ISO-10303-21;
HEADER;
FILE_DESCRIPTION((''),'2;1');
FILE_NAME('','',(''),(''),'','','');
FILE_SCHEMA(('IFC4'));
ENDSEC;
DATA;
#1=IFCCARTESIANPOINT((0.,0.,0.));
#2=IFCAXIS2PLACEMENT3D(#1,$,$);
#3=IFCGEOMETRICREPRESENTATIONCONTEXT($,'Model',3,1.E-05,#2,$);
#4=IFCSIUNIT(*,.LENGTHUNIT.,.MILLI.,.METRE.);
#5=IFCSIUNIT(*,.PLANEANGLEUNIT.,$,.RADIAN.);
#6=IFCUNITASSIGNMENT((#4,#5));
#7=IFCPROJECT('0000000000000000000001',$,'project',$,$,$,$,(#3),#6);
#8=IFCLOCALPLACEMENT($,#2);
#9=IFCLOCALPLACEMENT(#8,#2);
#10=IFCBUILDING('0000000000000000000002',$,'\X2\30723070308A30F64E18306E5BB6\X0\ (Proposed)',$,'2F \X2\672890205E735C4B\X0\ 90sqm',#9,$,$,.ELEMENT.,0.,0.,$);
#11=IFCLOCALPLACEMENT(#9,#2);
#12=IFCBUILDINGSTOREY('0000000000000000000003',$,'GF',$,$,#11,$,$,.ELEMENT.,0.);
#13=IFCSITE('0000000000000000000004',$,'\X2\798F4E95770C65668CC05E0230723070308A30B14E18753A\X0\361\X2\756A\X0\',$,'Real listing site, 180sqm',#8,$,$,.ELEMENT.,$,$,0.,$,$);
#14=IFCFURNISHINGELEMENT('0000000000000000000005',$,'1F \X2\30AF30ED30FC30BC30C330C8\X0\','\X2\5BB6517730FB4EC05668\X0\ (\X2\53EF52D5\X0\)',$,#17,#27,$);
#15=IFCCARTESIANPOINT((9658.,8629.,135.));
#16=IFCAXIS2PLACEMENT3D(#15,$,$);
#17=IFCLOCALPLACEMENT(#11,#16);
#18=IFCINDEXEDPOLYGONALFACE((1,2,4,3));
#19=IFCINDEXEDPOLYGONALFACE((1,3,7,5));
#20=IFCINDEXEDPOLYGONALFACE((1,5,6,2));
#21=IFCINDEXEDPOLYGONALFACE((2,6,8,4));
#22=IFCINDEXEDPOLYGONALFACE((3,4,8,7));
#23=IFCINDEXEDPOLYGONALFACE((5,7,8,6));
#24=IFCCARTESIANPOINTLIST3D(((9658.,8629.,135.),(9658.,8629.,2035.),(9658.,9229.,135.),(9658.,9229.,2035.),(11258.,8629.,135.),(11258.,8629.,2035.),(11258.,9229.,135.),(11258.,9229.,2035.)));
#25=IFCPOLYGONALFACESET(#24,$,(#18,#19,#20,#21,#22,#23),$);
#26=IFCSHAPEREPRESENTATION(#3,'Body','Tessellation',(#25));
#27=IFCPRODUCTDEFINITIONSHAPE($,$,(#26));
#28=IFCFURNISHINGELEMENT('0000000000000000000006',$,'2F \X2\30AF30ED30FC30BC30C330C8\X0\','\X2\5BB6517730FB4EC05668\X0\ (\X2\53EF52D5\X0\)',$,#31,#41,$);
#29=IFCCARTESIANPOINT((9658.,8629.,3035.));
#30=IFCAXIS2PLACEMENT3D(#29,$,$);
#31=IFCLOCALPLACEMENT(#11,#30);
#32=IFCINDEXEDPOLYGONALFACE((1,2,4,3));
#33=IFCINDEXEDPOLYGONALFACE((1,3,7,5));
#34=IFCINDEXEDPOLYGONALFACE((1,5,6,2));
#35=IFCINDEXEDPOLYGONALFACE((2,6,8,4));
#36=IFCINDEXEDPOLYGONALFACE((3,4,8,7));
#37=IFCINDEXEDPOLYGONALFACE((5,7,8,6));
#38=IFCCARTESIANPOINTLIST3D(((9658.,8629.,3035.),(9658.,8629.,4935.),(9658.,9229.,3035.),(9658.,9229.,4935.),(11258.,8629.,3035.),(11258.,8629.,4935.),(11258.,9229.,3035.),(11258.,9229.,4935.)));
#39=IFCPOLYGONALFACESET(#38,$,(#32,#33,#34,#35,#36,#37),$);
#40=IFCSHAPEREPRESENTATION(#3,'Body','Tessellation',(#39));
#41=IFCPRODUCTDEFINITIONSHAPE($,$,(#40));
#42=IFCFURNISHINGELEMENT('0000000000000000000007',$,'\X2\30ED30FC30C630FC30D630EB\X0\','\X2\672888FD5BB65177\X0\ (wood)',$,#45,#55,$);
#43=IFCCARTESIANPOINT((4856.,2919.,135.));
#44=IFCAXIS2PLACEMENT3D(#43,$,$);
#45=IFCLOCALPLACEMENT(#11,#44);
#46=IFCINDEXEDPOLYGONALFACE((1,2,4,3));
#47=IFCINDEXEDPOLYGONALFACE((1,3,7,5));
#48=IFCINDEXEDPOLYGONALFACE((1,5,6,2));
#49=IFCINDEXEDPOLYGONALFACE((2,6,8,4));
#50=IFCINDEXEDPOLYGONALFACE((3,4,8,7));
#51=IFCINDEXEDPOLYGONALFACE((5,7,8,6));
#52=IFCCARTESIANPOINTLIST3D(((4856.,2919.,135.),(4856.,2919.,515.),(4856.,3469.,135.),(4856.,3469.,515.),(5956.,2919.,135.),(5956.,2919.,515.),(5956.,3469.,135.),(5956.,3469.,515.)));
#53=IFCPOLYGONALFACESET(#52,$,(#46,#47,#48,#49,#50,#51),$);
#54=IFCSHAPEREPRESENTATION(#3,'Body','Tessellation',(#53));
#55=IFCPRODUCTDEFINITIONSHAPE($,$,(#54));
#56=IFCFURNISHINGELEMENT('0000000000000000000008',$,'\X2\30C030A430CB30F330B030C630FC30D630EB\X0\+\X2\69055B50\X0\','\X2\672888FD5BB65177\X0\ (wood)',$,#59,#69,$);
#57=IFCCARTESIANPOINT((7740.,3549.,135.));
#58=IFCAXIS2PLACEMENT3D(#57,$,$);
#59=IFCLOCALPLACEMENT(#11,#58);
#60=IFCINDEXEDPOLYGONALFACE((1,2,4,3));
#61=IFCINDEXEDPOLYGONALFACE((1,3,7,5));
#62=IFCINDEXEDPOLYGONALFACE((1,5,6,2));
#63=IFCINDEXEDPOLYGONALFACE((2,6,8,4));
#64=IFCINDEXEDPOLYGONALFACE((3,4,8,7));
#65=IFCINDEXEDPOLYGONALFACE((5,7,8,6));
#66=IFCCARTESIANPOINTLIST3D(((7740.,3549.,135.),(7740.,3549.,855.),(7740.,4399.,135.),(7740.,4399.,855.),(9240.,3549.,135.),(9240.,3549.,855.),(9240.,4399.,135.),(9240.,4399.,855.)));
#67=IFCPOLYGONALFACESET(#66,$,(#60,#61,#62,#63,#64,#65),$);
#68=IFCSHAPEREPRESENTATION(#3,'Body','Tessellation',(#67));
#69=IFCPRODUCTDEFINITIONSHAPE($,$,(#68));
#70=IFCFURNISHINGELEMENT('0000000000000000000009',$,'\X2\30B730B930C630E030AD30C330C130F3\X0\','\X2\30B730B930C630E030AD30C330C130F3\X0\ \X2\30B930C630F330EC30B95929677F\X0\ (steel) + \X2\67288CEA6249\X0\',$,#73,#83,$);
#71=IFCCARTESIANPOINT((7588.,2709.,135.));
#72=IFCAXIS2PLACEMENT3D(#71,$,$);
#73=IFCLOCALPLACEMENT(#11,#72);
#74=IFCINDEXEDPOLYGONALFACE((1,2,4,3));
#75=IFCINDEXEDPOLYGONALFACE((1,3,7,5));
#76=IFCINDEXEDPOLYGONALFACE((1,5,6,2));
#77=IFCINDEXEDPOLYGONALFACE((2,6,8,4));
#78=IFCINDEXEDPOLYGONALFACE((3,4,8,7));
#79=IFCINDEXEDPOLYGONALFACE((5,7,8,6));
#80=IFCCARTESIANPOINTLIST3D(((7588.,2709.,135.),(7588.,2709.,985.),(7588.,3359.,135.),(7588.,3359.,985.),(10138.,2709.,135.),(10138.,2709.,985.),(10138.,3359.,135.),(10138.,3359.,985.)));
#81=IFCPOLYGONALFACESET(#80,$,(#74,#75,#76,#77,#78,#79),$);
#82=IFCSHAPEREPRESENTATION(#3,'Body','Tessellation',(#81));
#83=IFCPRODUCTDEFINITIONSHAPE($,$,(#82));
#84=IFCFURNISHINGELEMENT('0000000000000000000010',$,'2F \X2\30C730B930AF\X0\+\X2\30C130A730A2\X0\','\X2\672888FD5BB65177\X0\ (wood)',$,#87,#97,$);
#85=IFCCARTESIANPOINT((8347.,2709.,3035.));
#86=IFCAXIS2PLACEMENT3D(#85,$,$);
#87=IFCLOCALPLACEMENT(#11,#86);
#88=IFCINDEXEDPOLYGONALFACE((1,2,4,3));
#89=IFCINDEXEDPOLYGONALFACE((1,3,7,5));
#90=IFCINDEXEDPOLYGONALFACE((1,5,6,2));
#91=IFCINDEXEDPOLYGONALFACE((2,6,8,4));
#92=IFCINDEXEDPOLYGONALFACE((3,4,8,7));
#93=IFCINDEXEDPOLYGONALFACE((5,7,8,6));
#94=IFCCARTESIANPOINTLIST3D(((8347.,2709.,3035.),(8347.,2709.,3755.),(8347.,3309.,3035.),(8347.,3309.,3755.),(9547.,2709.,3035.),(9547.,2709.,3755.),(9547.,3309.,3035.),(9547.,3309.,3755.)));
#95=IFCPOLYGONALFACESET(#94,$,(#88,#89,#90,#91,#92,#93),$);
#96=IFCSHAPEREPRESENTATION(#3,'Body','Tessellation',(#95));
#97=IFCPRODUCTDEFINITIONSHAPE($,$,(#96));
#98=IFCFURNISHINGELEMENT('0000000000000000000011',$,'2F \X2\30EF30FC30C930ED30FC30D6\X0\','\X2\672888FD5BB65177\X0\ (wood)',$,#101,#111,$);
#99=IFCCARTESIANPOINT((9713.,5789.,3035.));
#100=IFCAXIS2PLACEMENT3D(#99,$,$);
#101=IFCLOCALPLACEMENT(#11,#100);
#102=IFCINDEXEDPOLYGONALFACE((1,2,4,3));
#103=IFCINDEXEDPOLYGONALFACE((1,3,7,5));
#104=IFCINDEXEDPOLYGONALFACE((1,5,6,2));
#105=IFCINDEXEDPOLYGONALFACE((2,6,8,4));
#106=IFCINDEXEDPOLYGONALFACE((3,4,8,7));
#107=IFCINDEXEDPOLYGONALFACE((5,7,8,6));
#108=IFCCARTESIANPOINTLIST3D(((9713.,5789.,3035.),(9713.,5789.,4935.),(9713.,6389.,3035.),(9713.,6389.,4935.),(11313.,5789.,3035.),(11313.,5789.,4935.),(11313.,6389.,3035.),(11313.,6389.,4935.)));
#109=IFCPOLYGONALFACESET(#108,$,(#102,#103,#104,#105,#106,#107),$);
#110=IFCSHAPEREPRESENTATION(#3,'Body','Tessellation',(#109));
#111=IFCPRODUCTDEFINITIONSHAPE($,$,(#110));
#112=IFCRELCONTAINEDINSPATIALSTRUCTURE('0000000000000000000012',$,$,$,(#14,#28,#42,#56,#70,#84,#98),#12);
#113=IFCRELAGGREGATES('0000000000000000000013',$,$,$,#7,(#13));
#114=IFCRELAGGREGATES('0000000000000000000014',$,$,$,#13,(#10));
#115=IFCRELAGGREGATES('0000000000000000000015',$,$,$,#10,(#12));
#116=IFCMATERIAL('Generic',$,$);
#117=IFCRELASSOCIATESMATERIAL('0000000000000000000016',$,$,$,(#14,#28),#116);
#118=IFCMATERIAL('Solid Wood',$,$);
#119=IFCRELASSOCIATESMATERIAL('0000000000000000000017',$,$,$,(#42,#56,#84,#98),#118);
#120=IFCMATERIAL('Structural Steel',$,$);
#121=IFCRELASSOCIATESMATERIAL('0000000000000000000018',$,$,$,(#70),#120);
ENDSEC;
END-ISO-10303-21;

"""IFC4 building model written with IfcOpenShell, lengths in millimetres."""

from ifc_helpers import new_model, si_unit, frame, frame_2d, origin, place, context, project, spatial, rectangle, extrude, material, element, save


model = new_model("IFC4")

# Units and contexts
model_context = context("Model", 3, precision=1e-05, world=origin())
ifc_project = project(units=[si_unit("LENGTHUNIT", "METRE", prefix="MILLI"), si_unit("PLANEANGLEUNIT", "RADIAN")], contexts=[model_context])

# Site, building, storey
site_placement = place(None, origin())
site = spatial("IfcSite", under=ifc_project, at=site_placement, Name="福井県敦賀市ひばりケ丘町361番", ObjectType="Real listing site, 180sqm", CompositionType="ELEMENT", RefElevation=0.0)
building_placement = place(site_placement, origin())
building = spatial("IfcBuilding", under=site, at=building_placement, Name="ひばりヶ丘の家 (Proposed)", ObjectType="2F 木造平屋 90sqm", CompositionType="ELEMENT", ElevationOfRefHeight=0.0, ElevationOfTerrain=0.0)
storey_placement = place(building_placement, origin())
storey = spatial("IfcBuildingStorey", under=building, at=storey_placement, Name="GF", CompositionType="ELEMENT", Elevation=0.0)

# Shared definitions
ifc_material_1 = material(Name="Solid Wood")

# Shared definitions
ifc_material_2 = material(Name="Generic")

# Furnishing elements
furnishing_1_placement = place(storey_placement, frame((9658.0, 8629.0, 135.0)))
element("IfcFurnishingElement", 1, at=furnishing_1_placement, inside=storey, material=ifc_material_2, Name="1F クローゼット", Description="家具・什器 (可動)", context=model_context, shape_type="SweptSolid", body=[
    extrude(rectangle(XDim=1600.0, YDim=600.0, at=frame_2d((800.0, 300.0))), frame((9658.0, 8629.0, 135.0)), (0.0, 0.0, 1.0), 1900.0),
])
furnishing_2_placement = place(storey_placement, frame((9658.0, 8629.0, 3035.0)))
element("IfcFurnishingElement", 2, at=furnishing_2_placement, inside=storey, material=ifc_material_2, Name="2F クローゼット", Description="家具・什器 (可動)", context=model_context, shape_type="SweptSolid", body=[
    extrude(rectangle(XDim=1600.0, YDim=600.0, at=frame_2d((800.0, 300.0))), frame((9658.0, 8629.0, 3035.0)), (0.0, 0.0, 1.0), 1900.0),
])
furnishing_3_placement = place(storey_placement, frame((4856.0, 2919.0, 135.0)))
element("IfcFurnishingElement", 3, at=furnishing_3_placement, inside=storey, material=ifc_material_1, Name="ローテーブル", Description="木製家具 (wood)", context=model_context, shape_type="SweptSolid", body=[
    extrude(rectangle(XDim=1100.0, YDim=550.0, at=frame_2d((550.0, 275.0))), frame((4856.0, 2919.0, 135.0)), (0.0, 0.0, 1.0), 380.0),
])
furnishing_4_placement = place(storey_placement, frame((7740.0, 3549.0, 135.0)))
element("IfcFurnishingElement", 4, at=furnishing_4_placement, inside=storey, material=ifc_material_1, Name="ダイニングテーブル+椅子", Description="木製家具 (wood)", context=model_context, shape_type="SweptSolid", body=[
    extrude(rectangle(XDim=1500.0, YDim=850.0, at=frame_2d((750.0, 425.0))), frame((7740.0, 3549.0, 135.0)), (0.0, 0.0, 1.0), 720.0),
])
ifc_material_3 = material(Name="Structural Steel")
furnishing_5_placement = place(storey_placement, frame((7588.0, 2709.0, 135.0)))
element("IfcFurnishingElement", 5, at=furnishing_5_placement, inside=storey, material=ifc_material_3, Name="システムキッチン", Description="システムキッチン ステンレス天板 (steel) + 木質扉", context=model_context, shape_type="SweptSolid", body=[
    extrude(rectangle(XDim=2550.0, YDim=650.0, at=frame_2d((1275.0, 325.0))), frame((7588.0, 2709.0, 135.0)), (0.0, 0.0, 1.0), 850.0),
])
furnishing_6_placement = place(storey_placement, frame((8347.0, 2709.0, 3035.0)))
element("IfcFurnishingElement", 6, at=furnishing_6_placement, inside=storey, material=ifc_material_1, Name="2F デスク+チェア", Description="木製家具 (wood)", context=model_context, shape_type="SweptSolid", body=[
    extrude(rectangle(XDim=1200.0, YDim=600.0, at=frame_2d((600.0, 300.0))), frame((8347.0, 2709.0, 3035.0)), (0.0, 0.0, 1.0), 720.0),
])
furnishing_7_placement = place(storey_placement, frame((9713.0, 5789.0, 3035.0)))
element("IfcFurnishingElement", 7, at=furnishing_7_placement, inside=storey, material=ifc_material_1, Name="2F ワードローブ", Description="木製家具 (wood)", context=model_context, shape_type="SweptSolid", body=[
    extrude(rectangle(XDim=1600.0, YDim=600.0, at=frame_2d((800.0, 300.0))), frame((9713.0, 5789.0, 3035.0)), (0.0, 0.0, 1.0), 1900.0),
])

save(model, "model.ifc")
